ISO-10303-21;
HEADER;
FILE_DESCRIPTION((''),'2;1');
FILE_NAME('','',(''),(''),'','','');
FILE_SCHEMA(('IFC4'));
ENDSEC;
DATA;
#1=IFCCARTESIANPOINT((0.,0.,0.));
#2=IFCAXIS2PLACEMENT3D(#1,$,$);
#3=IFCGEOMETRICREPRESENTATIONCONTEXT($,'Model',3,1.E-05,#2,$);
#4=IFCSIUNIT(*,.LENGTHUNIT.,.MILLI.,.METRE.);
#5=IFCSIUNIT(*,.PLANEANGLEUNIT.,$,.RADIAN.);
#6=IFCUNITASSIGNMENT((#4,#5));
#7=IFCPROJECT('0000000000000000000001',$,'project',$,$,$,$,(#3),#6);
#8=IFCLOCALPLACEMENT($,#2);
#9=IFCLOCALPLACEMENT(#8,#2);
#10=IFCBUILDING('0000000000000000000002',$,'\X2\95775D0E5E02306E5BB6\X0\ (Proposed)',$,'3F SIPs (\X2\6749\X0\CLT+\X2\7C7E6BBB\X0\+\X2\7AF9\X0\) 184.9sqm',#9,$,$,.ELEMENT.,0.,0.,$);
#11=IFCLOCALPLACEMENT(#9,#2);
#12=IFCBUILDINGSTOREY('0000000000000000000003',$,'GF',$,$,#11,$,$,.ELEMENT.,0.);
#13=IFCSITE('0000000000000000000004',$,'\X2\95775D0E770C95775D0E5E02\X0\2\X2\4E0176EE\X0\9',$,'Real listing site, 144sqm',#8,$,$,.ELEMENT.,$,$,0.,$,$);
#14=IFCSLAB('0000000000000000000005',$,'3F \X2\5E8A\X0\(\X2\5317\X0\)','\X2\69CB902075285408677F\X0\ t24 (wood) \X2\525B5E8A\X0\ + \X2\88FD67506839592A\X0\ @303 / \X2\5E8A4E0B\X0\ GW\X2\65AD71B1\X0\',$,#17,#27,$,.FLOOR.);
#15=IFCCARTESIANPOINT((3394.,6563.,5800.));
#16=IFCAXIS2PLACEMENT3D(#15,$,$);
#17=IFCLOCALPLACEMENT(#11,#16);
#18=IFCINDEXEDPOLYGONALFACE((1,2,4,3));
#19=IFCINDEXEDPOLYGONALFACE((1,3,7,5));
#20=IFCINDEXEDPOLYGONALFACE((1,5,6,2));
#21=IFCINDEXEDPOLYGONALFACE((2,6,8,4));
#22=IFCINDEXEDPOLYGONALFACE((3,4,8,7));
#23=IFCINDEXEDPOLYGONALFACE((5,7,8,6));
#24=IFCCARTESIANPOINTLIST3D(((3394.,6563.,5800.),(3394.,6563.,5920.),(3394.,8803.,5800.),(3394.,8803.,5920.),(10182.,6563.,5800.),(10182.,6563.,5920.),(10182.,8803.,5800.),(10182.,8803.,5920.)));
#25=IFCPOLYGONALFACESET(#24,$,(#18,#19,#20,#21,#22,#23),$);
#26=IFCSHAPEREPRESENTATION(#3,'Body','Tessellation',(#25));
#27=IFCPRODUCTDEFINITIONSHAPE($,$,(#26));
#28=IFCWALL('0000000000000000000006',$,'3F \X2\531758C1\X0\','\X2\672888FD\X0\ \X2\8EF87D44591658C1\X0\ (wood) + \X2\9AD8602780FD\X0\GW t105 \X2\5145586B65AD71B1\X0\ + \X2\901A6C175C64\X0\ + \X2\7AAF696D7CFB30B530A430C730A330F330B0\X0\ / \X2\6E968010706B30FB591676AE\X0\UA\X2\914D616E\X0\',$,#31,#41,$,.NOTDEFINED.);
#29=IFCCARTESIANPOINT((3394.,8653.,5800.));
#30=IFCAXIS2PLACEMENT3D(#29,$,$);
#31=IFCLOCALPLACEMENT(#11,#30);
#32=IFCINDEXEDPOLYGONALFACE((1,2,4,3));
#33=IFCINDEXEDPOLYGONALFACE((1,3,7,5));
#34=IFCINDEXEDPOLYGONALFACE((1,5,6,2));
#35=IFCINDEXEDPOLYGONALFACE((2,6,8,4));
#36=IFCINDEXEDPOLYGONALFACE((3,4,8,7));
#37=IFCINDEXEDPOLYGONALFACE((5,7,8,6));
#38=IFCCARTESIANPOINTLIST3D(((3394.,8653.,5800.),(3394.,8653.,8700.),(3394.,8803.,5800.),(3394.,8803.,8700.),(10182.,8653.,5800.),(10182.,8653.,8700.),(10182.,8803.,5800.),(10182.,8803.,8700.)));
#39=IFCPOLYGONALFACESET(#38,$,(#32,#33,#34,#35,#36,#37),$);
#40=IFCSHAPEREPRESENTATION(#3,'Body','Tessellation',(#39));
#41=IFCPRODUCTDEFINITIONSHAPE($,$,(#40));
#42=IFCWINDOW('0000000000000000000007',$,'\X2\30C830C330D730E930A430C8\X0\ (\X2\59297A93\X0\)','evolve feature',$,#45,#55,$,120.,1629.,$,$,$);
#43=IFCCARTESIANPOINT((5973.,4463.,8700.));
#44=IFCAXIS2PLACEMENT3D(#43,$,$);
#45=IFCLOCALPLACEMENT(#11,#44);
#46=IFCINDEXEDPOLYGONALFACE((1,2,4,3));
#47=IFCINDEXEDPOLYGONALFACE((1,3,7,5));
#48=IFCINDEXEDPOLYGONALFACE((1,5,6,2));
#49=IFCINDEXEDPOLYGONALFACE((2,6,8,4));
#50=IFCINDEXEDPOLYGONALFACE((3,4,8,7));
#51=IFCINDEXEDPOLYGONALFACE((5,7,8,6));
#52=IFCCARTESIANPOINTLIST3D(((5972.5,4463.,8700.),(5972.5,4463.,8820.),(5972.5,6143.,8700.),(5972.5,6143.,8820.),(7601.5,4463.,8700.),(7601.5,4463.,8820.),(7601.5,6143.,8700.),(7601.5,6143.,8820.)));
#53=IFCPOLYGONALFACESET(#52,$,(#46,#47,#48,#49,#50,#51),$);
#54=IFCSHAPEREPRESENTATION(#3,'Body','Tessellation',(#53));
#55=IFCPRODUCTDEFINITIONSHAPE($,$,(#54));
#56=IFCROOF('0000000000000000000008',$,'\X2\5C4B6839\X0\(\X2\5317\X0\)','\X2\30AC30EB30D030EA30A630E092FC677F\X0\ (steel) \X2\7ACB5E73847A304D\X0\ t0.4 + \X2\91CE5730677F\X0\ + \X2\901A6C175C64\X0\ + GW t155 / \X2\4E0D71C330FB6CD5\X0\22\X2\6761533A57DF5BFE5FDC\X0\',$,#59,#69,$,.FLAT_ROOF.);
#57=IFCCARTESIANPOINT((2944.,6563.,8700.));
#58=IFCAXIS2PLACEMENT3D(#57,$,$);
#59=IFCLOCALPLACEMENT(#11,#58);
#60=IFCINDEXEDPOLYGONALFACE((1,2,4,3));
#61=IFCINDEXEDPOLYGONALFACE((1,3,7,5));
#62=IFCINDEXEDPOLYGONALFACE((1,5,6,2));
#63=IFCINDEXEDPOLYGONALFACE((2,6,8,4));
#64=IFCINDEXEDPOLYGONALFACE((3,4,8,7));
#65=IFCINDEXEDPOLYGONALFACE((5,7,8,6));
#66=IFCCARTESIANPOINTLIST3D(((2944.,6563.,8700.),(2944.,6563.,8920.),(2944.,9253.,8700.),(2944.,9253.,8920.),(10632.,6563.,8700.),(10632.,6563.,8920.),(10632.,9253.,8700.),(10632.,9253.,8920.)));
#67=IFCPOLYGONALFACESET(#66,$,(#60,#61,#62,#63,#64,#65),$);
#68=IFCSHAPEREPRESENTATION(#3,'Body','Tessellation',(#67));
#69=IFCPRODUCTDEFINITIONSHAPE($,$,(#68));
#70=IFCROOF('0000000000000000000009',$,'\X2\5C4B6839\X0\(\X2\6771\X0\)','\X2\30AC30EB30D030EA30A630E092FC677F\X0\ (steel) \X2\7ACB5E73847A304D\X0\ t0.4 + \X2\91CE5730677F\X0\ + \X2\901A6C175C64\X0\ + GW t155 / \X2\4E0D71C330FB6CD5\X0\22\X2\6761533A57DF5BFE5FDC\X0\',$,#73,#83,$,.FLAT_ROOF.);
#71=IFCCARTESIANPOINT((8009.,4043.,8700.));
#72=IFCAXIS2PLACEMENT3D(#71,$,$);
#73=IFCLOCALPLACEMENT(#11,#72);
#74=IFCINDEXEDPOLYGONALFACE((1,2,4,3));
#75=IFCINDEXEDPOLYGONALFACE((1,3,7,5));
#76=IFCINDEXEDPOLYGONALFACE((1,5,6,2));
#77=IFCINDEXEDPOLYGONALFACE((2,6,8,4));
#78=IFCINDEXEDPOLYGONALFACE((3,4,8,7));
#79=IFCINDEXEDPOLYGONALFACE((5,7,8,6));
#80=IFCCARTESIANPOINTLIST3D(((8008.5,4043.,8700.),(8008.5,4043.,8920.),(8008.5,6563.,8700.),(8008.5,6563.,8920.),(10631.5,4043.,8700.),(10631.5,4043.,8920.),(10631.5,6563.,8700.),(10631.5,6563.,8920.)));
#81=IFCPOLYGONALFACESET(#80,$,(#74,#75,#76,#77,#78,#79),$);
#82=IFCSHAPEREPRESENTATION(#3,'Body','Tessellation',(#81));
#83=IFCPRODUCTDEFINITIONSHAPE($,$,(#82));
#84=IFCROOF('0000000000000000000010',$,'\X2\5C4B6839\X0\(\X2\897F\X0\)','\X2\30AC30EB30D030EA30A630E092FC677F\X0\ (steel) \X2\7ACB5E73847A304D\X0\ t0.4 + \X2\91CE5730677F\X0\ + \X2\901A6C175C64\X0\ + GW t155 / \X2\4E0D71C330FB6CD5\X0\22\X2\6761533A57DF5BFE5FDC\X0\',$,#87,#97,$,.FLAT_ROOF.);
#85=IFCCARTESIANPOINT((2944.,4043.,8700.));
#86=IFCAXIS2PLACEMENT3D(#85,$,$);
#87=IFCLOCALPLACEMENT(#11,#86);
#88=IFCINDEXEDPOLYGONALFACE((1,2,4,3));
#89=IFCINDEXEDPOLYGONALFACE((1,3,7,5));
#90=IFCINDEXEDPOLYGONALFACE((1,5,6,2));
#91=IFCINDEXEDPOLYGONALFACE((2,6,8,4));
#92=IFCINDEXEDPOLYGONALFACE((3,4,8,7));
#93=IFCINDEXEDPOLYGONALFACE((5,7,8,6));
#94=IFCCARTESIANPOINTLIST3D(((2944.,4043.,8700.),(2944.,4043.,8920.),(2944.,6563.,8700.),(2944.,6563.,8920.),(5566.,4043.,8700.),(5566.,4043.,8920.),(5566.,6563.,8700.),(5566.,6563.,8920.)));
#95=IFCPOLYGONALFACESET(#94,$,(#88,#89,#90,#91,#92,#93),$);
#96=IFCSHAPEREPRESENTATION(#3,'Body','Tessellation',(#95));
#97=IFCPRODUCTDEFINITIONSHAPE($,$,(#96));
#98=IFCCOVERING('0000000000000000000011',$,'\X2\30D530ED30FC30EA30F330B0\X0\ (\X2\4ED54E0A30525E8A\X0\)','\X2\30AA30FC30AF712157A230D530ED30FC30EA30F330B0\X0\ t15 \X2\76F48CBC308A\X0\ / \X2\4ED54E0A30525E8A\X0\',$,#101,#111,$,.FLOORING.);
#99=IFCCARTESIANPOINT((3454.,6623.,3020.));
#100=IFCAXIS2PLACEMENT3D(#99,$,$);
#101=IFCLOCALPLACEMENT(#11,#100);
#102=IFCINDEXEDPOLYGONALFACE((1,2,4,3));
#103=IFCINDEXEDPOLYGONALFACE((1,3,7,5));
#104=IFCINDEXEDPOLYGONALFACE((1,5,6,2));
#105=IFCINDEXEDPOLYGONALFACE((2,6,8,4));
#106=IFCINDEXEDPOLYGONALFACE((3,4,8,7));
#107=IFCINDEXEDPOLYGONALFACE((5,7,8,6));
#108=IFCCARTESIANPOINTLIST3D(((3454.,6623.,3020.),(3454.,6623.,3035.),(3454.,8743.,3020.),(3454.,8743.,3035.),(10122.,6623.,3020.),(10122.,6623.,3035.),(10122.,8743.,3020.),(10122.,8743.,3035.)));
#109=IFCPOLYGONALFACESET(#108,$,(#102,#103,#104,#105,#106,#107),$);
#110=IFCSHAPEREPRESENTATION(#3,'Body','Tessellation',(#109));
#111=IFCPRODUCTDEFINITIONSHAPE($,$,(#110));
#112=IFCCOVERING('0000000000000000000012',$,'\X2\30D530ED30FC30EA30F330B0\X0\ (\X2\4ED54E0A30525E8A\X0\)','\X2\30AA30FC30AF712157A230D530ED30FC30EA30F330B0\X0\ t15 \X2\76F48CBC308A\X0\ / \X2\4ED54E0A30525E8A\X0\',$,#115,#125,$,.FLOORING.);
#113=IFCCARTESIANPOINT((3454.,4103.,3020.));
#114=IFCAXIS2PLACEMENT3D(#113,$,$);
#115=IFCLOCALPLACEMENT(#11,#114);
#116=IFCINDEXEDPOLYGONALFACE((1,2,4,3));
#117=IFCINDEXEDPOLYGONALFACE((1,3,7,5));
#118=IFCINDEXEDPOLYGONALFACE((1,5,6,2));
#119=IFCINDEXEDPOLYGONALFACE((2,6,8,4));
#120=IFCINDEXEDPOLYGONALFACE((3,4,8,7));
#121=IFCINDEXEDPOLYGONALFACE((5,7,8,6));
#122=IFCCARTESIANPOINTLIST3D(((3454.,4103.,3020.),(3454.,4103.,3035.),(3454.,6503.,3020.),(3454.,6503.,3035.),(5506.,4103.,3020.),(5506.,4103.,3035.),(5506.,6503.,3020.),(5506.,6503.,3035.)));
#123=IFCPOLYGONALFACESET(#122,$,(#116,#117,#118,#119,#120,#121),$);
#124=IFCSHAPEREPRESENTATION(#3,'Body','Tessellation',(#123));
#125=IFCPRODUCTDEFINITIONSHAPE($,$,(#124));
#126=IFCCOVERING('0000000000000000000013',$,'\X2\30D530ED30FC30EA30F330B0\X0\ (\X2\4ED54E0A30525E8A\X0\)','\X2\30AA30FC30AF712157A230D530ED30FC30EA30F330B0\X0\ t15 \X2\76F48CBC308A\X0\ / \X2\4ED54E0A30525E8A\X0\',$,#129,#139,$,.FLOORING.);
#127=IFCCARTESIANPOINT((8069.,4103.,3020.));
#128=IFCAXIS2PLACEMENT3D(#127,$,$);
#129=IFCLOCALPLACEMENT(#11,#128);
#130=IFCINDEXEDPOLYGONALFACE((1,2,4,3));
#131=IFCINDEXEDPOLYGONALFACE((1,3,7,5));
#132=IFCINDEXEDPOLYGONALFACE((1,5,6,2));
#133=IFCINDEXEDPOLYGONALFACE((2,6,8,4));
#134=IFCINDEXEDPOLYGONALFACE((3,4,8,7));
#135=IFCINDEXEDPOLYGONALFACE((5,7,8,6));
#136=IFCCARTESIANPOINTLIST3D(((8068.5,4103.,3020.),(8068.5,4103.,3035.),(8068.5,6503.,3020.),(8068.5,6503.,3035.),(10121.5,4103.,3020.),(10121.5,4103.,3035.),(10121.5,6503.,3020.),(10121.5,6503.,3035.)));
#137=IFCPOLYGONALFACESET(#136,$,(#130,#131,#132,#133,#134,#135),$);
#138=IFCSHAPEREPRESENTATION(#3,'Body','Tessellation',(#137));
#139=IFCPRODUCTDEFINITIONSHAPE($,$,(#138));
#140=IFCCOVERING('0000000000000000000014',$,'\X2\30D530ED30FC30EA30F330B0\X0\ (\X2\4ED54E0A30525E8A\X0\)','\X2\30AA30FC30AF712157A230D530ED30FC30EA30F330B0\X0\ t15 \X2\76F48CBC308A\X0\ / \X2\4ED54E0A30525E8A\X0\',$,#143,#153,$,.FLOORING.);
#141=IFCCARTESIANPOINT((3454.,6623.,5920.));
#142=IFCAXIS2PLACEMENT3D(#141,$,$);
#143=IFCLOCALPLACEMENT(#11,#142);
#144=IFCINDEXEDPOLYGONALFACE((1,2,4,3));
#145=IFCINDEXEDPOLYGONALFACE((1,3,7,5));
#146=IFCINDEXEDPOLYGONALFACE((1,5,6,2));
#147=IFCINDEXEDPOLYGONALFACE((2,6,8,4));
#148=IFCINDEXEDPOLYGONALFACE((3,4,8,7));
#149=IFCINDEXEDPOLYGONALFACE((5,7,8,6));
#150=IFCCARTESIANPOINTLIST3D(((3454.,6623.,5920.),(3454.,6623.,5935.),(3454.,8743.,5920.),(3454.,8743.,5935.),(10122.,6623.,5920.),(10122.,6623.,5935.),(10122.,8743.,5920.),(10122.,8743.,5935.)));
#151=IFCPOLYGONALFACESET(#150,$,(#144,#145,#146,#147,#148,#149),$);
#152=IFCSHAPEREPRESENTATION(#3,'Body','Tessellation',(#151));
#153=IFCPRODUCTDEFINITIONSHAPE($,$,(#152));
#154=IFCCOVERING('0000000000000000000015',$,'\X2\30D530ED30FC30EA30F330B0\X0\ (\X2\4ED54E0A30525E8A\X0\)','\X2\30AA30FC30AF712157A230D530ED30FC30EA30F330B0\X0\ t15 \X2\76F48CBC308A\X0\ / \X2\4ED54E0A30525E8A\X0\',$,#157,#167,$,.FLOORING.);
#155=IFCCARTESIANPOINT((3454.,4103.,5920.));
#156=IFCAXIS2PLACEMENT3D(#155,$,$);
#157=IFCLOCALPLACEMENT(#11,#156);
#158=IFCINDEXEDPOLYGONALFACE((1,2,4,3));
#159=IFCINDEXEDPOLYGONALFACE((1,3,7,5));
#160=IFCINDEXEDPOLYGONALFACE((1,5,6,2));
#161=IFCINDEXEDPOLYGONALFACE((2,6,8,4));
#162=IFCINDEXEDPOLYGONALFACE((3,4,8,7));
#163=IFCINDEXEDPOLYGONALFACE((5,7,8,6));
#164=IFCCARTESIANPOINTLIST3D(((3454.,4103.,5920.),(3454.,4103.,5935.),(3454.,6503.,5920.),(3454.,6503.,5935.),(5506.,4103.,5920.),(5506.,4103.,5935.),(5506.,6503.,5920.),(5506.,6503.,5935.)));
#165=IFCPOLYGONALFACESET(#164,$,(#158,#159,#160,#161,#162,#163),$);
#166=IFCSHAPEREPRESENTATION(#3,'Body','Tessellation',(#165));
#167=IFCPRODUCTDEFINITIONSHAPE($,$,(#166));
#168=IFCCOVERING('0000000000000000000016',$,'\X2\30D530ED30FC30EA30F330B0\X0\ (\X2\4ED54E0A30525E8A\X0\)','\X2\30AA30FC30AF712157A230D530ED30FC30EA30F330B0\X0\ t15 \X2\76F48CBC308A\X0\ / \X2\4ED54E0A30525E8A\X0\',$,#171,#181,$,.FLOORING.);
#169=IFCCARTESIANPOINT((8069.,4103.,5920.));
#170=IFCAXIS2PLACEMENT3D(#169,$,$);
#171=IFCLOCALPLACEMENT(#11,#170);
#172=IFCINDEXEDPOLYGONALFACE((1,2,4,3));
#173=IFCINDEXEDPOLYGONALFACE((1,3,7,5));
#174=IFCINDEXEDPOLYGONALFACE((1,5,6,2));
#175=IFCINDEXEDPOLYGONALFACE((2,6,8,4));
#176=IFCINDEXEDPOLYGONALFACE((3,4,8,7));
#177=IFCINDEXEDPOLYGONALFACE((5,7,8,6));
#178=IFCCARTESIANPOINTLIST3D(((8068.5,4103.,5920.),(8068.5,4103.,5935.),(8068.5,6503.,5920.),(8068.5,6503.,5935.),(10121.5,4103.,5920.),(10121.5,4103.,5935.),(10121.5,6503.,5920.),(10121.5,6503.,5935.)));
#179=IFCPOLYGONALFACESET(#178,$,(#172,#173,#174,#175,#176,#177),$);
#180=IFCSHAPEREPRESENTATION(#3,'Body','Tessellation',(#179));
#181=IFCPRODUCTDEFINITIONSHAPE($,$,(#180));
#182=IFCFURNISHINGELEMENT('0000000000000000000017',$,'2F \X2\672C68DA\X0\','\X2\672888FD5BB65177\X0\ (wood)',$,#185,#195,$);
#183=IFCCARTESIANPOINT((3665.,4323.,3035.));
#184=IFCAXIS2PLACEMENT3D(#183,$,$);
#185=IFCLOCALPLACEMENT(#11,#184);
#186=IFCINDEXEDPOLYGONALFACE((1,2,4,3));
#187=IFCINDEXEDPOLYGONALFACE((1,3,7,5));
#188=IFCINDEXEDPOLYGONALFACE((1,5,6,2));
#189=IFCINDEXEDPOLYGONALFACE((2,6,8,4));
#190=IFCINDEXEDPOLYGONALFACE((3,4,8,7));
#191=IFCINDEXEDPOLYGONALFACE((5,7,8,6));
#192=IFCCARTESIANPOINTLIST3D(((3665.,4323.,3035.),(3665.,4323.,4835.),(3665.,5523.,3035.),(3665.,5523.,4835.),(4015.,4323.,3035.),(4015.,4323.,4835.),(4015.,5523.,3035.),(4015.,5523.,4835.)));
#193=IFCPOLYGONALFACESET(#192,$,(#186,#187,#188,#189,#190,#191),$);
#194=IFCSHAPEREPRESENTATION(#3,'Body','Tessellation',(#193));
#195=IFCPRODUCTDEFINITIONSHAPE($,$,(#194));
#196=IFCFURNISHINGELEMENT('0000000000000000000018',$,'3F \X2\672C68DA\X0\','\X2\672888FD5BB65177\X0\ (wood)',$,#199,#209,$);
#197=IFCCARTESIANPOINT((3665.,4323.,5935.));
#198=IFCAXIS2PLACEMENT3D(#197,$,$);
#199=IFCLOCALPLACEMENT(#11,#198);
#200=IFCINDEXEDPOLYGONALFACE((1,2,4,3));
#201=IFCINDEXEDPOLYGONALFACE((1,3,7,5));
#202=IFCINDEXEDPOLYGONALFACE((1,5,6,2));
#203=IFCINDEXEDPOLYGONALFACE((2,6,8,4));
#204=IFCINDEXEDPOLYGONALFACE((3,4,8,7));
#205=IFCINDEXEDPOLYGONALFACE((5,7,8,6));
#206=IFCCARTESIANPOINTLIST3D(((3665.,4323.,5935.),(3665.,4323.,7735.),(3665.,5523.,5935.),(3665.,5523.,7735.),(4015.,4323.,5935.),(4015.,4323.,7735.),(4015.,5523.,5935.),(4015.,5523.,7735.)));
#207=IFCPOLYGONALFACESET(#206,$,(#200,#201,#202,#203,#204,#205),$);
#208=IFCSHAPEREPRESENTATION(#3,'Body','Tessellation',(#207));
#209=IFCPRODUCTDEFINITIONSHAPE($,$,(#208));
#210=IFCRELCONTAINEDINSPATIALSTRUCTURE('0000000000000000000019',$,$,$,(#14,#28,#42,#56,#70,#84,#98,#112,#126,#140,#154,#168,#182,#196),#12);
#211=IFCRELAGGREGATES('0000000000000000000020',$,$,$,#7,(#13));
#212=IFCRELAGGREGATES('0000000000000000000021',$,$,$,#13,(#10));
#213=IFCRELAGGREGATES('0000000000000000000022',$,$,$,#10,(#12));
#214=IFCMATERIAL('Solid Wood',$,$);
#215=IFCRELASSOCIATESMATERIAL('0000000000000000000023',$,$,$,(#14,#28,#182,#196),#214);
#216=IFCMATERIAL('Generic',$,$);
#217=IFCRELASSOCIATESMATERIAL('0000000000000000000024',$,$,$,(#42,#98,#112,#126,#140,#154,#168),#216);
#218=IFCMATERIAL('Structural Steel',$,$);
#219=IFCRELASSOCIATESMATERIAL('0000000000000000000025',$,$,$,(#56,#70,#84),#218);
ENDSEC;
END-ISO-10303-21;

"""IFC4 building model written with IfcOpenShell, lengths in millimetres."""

from ifc_helpers import new_model, si_unit, frame, frame_2d, origin, place, context, project, spatial, rectangle, extrude, material, element, save


model = new_model("IFC4")

# Units and contexts
model_context = context("Model", 3, precision=1e-05, world=origin())
ifc_project = project(units=[si_unit("LENGTHUNIT", "METRE", prefix="MILLI"), si_unit("PLANEANGLEUNIT", "RADIAN")], contexts=[model_context])

# Site, building, storey
site_placement = place(None, origin())
site = spatial("IfcSite", under=ifc_project, at=site_placement, Name="長崎県長崎市2丁目9", ObjectType="Real listing site, 144sqm", CompositionType="ELEMENT", RefElevation=0.0)
building_placement = place(site_placement, origin())
building = spatial("IfcBuilding", under=site, at=building_placement, Name="長崎市の家 (Proposed)", ObjectType="3F SIPs (杉CLT+籾殻+竹) 184.9sqm", CompositionType="ELEMENT", ElevationOfRefHeight=0.0, ElevationOfTerrain=0.0)
storey_placement = place(building_placement, origin())
storey = spatial("IfcBuildingStorey", under=building, at=storey_placement, Name="GF", CompositionType="ELEMENT", Elevation=0.0)

# Slab
ifc_material_1 = material(Name="Solid Wood")
slab_placement = place(storey_placement, frame((3394.0, 6563.0, 5800.0)))
element("IfcSlab", 1, at=slab_placement, inside=storey, material=ifc_material_1, Name="3F 床(北)", Description="構造用合板 t24 (wood) 剛床 + 製材根太 @303 / 床下 GW断熱", PredefinedType="FLOOR", context=model_context, shape_type="SweptSolid", body=[
    extrude(rectangle(XDim=6788.0, YDim=2240.0, at=frame_2d((3394.0, 1120.0))), frame((3394.0, 6563.0, 5800.0)), (0.0, 0.0, 1.0), 120.0),
])

# Wall
wall_1_placement = place(storey_placement, frame((3394.0, 8653.0, 5800.0)))
element("IfcWall", 2, at=wall_1_placement, inside=storey, material=ifc_material_1, Name="3F 北壁", Description="木製 軸組外壁 (wood) + 高性能GW t105 充填断熱 + 通気層 + 窯業系サイディング / 準耐火・外皮UA配慮", PredefinedType="NOTDEFINED", context=model_context, shape_type="SweptSolid", body=[
    extrude(rectangle(XDim=6788.0, YDim=150.0, at=frame_2d((3394.0, 75.0))), frame((3394.0, 8653.0, 5800.0)), (0.0, 0.0, 1.0), 2900.0),
])

# Window
ifc_material_2 = material(Name="Generic")
window_1_placement = place(storey_placement, frame((5973.0, 4463.0, 8700.0)))
element("IfcWindow", 3, at=window_1_placement, inside=storey, material=ifc_material_2, Name="トップライト (天窓)", Description="evolve feature", OverallHeight=120.0, OverallWidth=1629.0, context=model_context, shape_type="SweptSolid", body=[
    extrude(rectangle(XDim=1629.0, YDim=1680.0, at=frame_2d((814.0, 840.0))), frame((5973.0, 4463.0, 8700.0)), (0.0, 0.0, 1.0), 120.0),
])

# Roofs
ifc_material_3 = material(Name="Structural Steel")
roof_1_placement = place(storey_placement, frame((2944.0, 6563.0, 8700.0)))
element("IfcRoof", 4, at=roof_1_placement, inside=storey, material=ifc_material_3, Name="屋根(北)", Description="ガルバリウム鋼板 (steel) 立平葺き t0.4 + 野地板 + 通気層 + GW t155 / 不燃・法22条区域対応", PredefinedType="FLAT_ROOF", context=model_context, shape_type="SweptSolid", body=[
    extrude(rectangle(XDim=7688.0, YDim=2690.0, at=frame_2d((3844.0, 1345.0))), frame((2944.0, 6563.0, 8700.0)), (0.0, 0.0, 1.0), 220.0),
])
roof_2_placement = place(storey_placement, frame((8009.0, 4043.0, 8700.0)))
element("IfcRoof", 5, at=roof_2_placement, inside=storey, material=ifc_material_3, Name="屋根(東)", Description="ガルバリウム鋼板 (steel) 立平葺き t0.4 + 野地板 + 通気層 + GW t155 / 不燃・法22条区域対応", PredefinedType="FLAT_ROOF", context=model_context, shape_type="SweptSolid", body=[
    extrude(rectangle(XDim=2623.0, YDim=2520.0, at=frame_2d((1311.0, 1260.0))), frame((8009.0, 4043.0, 8700.0)), (0.0, 0.0, 1.0), 220.0),
])
roof_3_placement = place(storey_placement, frame((2944.0, 4043.0, 8700.0)))
element("IfcRoof", 6, at=roof_3_placement, inside=storey, material=ifc_material_3, Name="屋根(西)", Description="ガルバリウム鋼板 (steel) 立平葺き t0.4 + 野地板 + 通気層 + GW t155 / 不燃・法22条区域対応", PredefinedType="FLAT_ROOF", context=model_context, shape_type="SweptSolid", body=[
    extrude(rectangle(XDim=2622.0, YDim=2520.0, at=frame_2d((1311.0, 1260.0))), frame((2944.0, 4043.0, 8700.0)), (0.0, 0.0, 1.0), 220.0),
])

# Coverings
covering_1_placement = place(storey_placement, frame((3454.0, 6623.0, 3020.0)))
element("IfcCovering", 7, at=covering_1_placement, inside=storey, material=ifc_material_2, Name="フローリング (仕上げ床)", Description="オーク無垢フローリング t15 直貼り / 仕上げ床", PredefinedType="FLOORING", context=model_context, shape_type="SweptSolid", body=[
    extrude(rectangle(XDim=6668.0, YDim=2120.0, at=frame_2d((3334.0, 1060.0))), frame((3454.0, 6623.0, 3020.0)), (0.0, 0.0, 1.0), 15.0),
])
covering_2_placement = place(storey_placement, frame((3454.0, 4103.0, 3020.0)))
element("IfcCovering", 8, at=covering_2_placement, inside=storey, material=ifc_material_2, Name="フローリング (仕上げ床)", Description="オーク無垢フローリング t15 直貼り / 仕上げ床", PredefinedType="FLOORING", context=model_context, shape_type="SweptSolid", body=[
    extrude(rectangle(XDim=2052.0, YDim=2400.0, at=frame_2d((1026.0, 1200.0))), frame((3454.0, 4103.0, 3020.0)), (0.0, 0.0, 1.0), 15.0),
])
covering_3_placement = place(storey_placement, frame((8069.0, 4103.0, 3020.0)))
element("IfcCovering", 9, at=covering_3_placement, inside=storey, material=ifc_material_2, Name="フローリング (仕上げ床)", Description="オーク無垢フローリング t15 直貼り / 仕上げ床", PredefinedType="FLOORING", context=model_context, shape_type="SweptSolid", body=[
    extrude(rectangle(XDim=2053.0, YDim=2400.0, at=frame_2d((1026.0, 1200.0))), frame((8069.0, 4103.0, 3020.0)), (0.0, 0.0, 1.0), 15.0),
])
covering_4_placement = place(storey_placement, frame((3454.0, 6623.0, 5920.0)))
element("IfcCovering", 10, at=covering_4_placement, inside=storey, material=ifc_material_2, Name="フローリング (仕上げ床)", Description="オーク無垢フローリング t15 直貼り / 仕上げ床", PredefinedType="FLOORING", context=model_context, shape_type="SweptSolid", body=[
    extrude(rectangle(XDim=6668.0, YDim=2120.0, at=frame_2d((3334.0, 1060.0))), frame((3454.0, 6623.0, 5920.0)), (0.0, 0.0, 1.0), 15.0),
])
covering_5_placement = place(storey_placement, frame((3454.0, 4103.0, 5920.0)))
element("IfcCovering", 11, at=covering_5_placement, inside=storey, material=ifc_material_2, Name="フローリング (仕上げ床)", Description="オーク無垢フローリング t15 直貼り / 仕上げ床", PredefinedType="FLOORING", context=model_context, shape_type="SweptSolid", body=[
    extrude(rectangle(XDim=2052.0, YDim=2400.0, at=frame_2d((1026.0, 1200.0))), frame((3454.0, 4103.0, 5920.0)), (0.0, 0.0, 1.0), 15.0),
])
covering_6_placement = place(storey_placement, frame((8069.0, 4103.0, 5920.0)))
element("IfcCovering", 12, at=covering_6_placement, inside=storey, material=ifc_material_2, Name="フローリング (仕上げ床)", Description="オーク無垢フローリング t15 直貼り / 仕上げ床", PredefinedType="FLOORING", context=model_context, shape_type="SweptSolid", body=[
    extrude(rectangle(XDim=2053.0, YDim=2400.0, at=frame_2d((1026.0, 1200.0))), frame((8069.0, 4103.0, 5920.0)), (0.0, 0.0, 1.0), 15.0),
])

# Furnishing elements
furnishing_1_placement = place(storey_placement, frame((3665.0, 4323.0, 3035.0)))
element("IfcFurnishingElement", 13, at=furnishing_1_placement, inside=storey, material=ifc_material_1, Name="2F 本棚", Description="木製家具 (wood)", context=model_context, shape_type="SweptSolid", body=[
    extrude(rectangle(XDim=350.0, YDim=1200.0, at=frame_2d((175.0, 600.0))), frame((3665.0, 4323.0, 3035.0)), (0.0, 0.0, 1.0), 1800.0),
])
furnishing_2_placement = place(storey_placement, frame((3665.0, 4323.0, 5935.0)))
element("IfcFurnishingElement", 14, at=furnishing_2_placement, inside=storey, material=ifc_material_1, Name="3F 本棚", Description="木製家具 (wood)", context=model_context, shape_type="SweptSolid", body=[
    extrude(rectangle(XDim=350.0, YDim=1200.0, at=frame_2d((175.0, 600.0))), frame((3665.0, 4323.0, 5935.0)), (0.0, 0.0, 1.0), 1800.0),
])

save(model, "model.ifc")
